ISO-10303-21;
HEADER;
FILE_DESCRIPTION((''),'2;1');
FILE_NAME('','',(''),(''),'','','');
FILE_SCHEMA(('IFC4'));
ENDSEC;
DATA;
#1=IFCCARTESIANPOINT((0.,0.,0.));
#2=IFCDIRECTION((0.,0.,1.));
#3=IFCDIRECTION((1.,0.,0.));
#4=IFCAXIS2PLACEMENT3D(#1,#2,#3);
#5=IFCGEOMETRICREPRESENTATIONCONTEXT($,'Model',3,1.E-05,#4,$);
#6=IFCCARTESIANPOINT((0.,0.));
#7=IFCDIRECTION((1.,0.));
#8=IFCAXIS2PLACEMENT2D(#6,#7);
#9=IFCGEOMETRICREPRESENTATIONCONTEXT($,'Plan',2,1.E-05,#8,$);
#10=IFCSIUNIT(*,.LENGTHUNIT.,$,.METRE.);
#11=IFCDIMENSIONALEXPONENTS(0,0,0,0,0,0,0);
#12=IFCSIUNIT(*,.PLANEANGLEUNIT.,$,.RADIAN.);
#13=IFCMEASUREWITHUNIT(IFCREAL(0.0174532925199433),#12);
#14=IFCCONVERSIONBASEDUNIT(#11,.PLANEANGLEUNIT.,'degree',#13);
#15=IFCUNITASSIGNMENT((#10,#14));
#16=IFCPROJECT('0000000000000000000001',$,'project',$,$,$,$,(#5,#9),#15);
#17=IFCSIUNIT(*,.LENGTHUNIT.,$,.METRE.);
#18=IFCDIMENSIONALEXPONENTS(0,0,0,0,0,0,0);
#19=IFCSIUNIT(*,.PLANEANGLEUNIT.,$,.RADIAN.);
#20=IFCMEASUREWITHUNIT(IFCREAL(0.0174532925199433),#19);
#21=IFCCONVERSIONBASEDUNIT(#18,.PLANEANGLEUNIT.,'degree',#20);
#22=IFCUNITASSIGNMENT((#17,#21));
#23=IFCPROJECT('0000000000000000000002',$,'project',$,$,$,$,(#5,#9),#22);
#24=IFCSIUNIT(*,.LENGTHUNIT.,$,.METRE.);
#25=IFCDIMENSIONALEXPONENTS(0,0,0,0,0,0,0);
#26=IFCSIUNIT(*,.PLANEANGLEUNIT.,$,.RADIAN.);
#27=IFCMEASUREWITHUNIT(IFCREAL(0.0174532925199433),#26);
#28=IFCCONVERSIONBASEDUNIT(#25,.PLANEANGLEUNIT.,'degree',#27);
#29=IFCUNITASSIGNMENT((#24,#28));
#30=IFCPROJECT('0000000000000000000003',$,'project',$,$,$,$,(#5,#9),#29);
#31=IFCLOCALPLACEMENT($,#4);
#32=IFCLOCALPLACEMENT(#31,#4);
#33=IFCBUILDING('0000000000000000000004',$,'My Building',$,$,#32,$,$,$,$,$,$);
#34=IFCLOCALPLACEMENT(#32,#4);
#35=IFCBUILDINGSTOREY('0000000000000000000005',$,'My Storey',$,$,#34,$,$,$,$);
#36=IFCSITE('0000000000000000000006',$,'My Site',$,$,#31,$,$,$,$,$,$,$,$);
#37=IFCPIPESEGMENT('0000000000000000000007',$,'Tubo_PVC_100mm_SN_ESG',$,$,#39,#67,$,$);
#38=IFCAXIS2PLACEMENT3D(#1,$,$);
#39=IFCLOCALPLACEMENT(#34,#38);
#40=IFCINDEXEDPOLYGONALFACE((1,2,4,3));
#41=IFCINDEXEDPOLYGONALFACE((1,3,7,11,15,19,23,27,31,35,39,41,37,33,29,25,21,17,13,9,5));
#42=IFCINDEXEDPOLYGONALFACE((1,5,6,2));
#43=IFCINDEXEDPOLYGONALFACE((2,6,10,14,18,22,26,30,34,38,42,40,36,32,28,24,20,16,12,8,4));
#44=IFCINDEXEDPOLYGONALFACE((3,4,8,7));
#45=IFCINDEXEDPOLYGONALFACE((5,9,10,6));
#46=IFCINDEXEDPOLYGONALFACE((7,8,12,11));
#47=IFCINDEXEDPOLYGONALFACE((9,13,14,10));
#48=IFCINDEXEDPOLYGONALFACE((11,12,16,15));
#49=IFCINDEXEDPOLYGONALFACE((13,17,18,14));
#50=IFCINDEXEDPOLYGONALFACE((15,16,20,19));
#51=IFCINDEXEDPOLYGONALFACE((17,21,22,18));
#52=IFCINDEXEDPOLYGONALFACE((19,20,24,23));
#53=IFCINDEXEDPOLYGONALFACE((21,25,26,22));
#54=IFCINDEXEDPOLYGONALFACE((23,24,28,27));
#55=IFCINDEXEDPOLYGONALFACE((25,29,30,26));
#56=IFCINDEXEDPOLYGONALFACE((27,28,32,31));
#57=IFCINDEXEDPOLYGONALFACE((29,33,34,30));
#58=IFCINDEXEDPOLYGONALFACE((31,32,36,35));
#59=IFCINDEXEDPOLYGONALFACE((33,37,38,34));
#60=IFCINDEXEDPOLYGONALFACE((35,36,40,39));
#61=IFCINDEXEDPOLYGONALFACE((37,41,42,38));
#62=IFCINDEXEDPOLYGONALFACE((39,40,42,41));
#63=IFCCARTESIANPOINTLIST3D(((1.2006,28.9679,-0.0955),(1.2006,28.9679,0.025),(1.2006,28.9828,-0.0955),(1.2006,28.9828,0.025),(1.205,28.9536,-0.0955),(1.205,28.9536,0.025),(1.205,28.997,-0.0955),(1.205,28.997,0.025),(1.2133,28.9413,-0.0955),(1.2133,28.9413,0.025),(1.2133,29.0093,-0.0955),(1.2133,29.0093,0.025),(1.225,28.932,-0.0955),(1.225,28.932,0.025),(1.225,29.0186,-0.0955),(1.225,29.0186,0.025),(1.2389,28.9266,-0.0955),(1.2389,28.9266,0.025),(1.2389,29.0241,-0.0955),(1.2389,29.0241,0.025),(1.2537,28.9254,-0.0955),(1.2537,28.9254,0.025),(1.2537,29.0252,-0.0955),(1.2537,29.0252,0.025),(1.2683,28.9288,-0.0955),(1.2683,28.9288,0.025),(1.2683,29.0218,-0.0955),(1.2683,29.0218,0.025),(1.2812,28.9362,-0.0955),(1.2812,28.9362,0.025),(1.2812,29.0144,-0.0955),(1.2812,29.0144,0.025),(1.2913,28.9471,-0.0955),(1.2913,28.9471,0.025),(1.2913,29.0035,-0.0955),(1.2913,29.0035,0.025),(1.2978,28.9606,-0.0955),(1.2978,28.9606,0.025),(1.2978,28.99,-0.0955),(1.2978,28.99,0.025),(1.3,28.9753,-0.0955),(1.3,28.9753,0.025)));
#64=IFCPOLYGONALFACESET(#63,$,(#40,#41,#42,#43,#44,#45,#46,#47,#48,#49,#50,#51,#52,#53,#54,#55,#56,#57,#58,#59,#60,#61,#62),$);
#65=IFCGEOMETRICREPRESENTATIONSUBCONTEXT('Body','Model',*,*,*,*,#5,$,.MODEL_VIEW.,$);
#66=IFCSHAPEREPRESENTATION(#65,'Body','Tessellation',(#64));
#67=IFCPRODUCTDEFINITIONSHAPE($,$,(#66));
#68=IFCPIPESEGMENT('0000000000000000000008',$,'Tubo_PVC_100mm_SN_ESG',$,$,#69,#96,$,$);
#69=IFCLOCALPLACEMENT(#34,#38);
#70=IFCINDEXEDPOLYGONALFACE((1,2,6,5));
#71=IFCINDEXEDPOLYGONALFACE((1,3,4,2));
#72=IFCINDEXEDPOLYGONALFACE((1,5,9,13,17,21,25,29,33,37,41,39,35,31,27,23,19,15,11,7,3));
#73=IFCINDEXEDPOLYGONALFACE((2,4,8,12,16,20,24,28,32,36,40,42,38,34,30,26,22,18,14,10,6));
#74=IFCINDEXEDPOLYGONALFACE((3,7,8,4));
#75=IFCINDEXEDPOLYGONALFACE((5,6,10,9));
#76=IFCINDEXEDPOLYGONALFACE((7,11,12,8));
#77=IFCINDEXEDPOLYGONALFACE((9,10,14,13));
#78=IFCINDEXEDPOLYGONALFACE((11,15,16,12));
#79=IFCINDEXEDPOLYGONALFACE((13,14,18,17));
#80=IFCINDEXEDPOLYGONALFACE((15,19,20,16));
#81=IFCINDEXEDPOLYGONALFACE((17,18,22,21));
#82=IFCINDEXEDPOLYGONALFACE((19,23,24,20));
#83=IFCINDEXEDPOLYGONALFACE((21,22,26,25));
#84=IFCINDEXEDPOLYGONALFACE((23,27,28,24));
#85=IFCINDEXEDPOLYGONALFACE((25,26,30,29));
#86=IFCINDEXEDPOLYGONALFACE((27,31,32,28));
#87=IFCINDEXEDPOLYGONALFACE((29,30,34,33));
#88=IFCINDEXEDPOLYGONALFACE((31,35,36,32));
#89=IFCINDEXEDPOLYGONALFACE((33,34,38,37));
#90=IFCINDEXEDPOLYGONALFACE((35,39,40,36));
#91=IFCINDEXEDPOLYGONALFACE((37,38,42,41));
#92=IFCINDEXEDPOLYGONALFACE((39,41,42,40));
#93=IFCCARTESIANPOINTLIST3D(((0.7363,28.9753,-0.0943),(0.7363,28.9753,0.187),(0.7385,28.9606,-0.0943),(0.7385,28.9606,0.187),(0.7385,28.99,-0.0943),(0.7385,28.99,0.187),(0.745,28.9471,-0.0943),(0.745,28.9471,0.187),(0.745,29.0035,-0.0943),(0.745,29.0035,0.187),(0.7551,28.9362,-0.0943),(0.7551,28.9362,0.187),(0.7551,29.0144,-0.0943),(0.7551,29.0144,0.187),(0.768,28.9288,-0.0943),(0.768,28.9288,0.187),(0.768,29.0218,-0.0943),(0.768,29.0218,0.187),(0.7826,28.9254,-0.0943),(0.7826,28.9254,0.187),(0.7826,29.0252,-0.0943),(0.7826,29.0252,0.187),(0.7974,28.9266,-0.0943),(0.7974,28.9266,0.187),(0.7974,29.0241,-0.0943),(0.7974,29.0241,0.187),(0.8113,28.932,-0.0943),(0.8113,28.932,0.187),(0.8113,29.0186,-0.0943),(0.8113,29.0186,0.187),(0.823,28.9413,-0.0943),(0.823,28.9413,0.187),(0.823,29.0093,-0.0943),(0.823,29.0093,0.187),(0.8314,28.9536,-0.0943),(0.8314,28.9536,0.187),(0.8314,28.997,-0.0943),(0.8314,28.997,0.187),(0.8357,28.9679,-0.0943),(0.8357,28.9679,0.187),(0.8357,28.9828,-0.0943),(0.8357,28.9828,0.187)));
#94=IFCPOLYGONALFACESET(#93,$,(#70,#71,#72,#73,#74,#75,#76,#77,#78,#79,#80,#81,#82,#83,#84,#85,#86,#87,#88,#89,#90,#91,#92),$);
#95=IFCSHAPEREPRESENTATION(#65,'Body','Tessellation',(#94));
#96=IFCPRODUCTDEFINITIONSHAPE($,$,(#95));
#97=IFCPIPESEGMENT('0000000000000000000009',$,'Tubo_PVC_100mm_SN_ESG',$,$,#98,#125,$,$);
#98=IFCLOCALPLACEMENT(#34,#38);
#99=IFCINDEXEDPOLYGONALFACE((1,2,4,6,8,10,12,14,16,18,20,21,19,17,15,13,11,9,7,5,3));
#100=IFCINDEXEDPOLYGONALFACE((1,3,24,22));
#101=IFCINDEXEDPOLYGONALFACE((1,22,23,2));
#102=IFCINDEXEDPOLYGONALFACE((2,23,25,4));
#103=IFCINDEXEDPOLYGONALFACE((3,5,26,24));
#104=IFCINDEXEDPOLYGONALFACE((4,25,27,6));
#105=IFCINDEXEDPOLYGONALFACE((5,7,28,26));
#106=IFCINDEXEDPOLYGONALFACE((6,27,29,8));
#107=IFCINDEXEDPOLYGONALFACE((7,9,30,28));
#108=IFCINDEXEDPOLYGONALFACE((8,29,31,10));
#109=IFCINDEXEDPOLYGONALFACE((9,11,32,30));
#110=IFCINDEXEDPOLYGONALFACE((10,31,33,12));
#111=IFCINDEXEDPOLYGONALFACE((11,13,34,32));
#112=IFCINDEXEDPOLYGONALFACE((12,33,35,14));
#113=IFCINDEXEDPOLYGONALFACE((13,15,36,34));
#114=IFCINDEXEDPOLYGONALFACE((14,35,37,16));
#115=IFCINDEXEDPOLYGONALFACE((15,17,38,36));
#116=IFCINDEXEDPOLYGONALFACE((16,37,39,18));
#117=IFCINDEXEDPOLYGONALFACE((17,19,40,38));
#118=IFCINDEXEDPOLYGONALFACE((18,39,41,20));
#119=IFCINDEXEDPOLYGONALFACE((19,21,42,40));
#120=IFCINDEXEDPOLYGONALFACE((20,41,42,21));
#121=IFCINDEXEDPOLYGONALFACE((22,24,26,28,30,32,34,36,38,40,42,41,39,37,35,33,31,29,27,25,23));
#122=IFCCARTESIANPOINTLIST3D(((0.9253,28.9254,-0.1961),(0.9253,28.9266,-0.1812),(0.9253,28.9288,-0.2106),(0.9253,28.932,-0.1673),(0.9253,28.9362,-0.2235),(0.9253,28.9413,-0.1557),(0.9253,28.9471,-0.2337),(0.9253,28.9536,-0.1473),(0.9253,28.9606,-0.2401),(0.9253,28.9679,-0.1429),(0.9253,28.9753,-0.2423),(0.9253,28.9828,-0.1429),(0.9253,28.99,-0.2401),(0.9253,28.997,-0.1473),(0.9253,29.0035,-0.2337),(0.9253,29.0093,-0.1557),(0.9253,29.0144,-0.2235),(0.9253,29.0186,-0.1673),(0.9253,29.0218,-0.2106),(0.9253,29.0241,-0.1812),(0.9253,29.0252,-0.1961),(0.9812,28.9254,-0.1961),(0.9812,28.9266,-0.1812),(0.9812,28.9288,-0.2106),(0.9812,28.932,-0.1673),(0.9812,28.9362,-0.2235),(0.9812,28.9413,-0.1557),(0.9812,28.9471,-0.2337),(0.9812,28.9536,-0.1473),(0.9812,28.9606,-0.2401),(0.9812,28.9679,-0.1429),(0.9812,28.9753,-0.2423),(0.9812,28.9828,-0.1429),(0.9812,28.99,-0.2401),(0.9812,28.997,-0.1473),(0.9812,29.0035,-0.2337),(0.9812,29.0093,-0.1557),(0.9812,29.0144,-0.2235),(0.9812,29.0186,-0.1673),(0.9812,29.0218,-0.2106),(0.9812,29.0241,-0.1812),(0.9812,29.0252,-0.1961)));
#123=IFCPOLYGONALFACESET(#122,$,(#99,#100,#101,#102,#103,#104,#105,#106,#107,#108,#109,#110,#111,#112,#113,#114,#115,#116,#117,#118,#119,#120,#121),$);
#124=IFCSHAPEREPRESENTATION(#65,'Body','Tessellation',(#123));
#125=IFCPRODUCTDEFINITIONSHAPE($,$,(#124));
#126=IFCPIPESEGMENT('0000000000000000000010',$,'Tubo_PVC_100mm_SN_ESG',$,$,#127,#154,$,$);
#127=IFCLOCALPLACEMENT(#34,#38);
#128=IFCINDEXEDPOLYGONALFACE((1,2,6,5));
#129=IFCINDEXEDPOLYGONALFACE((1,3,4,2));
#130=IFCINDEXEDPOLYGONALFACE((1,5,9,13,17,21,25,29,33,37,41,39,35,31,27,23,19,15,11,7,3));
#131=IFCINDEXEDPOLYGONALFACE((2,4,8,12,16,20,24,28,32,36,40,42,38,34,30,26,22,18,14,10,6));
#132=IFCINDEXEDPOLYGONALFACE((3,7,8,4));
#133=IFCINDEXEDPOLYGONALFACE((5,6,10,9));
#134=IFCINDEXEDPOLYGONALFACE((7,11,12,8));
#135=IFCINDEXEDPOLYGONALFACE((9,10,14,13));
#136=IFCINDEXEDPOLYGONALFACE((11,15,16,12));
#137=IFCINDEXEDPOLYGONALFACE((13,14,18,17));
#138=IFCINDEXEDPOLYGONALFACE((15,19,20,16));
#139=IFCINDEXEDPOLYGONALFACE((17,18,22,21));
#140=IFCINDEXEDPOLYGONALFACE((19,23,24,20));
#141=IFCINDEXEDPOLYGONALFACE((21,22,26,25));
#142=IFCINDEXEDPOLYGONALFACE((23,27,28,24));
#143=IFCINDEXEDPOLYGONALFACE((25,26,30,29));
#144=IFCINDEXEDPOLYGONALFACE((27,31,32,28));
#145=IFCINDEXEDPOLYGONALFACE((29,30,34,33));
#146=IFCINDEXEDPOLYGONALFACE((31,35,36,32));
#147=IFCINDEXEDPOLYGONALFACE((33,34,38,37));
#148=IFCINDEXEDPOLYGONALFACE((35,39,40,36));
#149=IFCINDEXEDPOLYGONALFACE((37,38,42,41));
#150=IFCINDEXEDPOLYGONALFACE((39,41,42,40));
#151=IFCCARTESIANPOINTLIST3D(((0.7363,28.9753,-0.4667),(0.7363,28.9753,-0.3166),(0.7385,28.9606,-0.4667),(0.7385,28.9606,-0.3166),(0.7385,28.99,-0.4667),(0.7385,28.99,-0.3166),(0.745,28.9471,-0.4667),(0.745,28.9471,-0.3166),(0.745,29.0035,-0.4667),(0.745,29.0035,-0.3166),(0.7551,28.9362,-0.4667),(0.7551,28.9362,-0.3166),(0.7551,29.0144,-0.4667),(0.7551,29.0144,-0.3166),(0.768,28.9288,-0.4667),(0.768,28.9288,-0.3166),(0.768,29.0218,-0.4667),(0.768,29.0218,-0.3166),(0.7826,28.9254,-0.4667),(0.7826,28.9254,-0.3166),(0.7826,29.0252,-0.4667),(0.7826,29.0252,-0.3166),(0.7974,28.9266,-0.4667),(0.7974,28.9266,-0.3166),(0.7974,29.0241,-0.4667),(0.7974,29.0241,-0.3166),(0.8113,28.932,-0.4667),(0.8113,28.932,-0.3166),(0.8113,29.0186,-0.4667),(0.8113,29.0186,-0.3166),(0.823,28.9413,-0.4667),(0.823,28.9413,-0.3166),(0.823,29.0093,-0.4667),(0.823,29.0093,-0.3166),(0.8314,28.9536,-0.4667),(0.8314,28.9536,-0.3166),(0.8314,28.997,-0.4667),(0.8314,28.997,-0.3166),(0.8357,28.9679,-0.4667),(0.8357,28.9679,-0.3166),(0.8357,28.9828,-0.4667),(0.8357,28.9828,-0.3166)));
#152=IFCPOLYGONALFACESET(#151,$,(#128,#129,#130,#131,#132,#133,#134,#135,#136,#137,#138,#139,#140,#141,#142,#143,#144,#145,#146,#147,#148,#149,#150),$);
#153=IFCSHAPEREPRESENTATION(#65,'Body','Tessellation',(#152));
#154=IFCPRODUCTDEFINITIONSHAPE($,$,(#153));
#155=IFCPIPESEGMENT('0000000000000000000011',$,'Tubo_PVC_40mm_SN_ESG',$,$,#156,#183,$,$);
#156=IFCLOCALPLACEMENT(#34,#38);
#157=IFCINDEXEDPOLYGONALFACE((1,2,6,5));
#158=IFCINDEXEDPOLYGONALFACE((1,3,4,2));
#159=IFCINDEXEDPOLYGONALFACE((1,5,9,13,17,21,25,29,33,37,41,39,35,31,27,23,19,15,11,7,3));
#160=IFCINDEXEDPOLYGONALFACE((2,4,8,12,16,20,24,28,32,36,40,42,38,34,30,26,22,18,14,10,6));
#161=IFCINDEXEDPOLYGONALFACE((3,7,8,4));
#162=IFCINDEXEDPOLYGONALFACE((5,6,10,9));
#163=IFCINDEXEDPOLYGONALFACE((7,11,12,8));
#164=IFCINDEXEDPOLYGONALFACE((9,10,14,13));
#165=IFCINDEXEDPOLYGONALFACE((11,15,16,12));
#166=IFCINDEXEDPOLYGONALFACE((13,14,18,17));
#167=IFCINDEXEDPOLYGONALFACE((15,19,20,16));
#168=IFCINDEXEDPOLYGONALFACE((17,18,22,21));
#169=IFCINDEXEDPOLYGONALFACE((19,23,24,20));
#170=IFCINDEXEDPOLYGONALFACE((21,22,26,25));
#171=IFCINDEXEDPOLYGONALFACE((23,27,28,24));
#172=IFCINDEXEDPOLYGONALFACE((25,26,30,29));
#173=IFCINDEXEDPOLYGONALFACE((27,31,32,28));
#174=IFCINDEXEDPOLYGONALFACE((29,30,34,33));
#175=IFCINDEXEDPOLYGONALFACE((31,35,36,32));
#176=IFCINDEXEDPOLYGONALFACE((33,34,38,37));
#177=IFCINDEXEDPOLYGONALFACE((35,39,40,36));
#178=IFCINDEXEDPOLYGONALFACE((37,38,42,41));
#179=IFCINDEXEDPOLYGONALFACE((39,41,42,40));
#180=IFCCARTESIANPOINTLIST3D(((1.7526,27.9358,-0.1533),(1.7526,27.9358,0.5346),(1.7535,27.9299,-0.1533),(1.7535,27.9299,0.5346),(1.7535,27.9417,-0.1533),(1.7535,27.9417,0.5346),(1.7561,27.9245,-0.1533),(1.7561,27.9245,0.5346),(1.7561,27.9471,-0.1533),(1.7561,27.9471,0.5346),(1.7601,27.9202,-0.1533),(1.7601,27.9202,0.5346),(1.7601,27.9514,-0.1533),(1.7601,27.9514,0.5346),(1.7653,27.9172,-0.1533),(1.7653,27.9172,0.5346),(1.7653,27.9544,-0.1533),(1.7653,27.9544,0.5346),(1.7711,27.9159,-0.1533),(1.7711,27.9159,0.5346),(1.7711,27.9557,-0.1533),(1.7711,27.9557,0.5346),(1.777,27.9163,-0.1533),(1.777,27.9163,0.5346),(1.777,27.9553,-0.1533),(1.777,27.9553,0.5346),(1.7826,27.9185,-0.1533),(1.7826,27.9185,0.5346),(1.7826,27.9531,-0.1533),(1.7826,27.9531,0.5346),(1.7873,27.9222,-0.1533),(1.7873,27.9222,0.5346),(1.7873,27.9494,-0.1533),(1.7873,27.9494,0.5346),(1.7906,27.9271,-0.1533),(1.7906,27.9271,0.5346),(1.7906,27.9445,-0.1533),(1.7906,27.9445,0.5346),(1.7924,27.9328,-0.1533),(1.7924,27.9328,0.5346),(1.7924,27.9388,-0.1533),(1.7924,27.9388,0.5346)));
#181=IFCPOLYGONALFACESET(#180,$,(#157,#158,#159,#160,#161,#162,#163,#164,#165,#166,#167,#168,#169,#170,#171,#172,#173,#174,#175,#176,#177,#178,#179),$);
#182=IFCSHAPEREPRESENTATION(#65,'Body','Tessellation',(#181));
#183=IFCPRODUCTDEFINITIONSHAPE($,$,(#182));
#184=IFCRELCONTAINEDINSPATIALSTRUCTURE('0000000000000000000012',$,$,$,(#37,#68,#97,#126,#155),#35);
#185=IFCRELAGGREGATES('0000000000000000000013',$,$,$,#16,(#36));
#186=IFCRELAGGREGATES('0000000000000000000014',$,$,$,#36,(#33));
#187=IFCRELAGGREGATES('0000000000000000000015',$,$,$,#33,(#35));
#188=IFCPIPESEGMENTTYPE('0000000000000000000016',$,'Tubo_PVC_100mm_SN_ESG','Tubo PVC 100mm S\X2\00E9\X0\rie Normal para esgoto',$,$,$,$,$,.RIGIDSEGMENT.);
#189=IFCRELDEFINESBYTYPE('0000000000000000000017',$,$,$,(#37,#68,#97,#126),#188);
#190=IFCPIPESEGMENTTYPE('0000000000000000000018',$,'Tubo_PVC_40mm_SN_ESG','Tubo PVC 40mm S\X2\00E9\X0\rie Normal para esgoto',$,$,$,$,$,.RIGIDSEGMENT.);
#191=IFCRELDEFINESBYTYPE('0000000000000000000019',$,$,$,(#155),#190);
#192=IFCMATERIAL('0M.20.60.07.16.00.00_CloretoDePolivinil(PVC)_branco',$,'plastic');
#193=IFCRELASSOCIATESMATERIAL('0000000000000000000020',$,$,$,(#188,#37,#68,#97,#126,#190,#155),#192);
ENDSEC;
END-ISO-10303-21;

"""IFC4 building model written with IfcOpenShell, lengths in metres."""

from ifc_helpers import new_model, entity, si_unit, converted_unit, frame, origin_with_axes, origin_2d_with_axis, place, context, subcontext, project, spatial, circle, extrude, material, material_profile, profile_set, profile_usage, type_object, element, save


model = new_model("IFC4")

# Units and contexts
model_context = context("Model", 3, precision=1e-05, world=origin_with_axes())
plan_context = context("Plan", 2, precision=1e-05, world=origin_2d_with_axis())
body_context_1 = subcontext(model_context, "Body", "Model", "MODEL_VIEW")
ifc_project_1 = project(units=[si_unit("LENGTHUNIT", "METRE"), converted_unit("PLANEANGLEUNIT", "degree", entity("IfcReal", 0.0174532925199433), si_unit("PLANEANGLEUNIT", "RADIAN"), dimensions=[0, 0, 0, 0, 0, 0, 0])], contexts=[model_context, plan_context])
ifc_project_2 = project(units=[si_unit("LENGTHUNIT", "METRE"), converted_unit("PLANEANGLEUNIT", "degree", entity("IfcReal", 0.0174532925199433), si_unit("PLANEANGLEUNIT", "RADIAN"), dimensions=[0, 0, 0, 0, 0, 0, 0])], contexts=[model_context, plan_context])
ifc_project_3 = project(units=[si_unit("LENGTHUNIT", "METRE"), converted_unit("PLANEANGLEUNIT", "degree", entity("IfcReal", 0.0174532925199433), si_unit("PLANEANGLEUNIT", "RADIAN"), dimensions=[0, 0, 0, 0, 0, 0, 0])], contexts=[model_context, plan_context])

# Site, building, storey
site_placement = place(None, origin_with_axes())
site = spatial("IfcSite", under=ifc_project_1, at=site_placement, Name="My Site")
building_placement = place(site_placement, origin_with_axes())
building = spatial("IfcBuilding", under=site, at=building_placement, Name="My Building")
storey_placement = place(building_placement, origin_with_axes())
storey = spatial("IfcBuildingStorey", under=building, at=storey_placement, Name="My Storey")

# Pipe segments
ifc_material_1 = material(Name="0M.20.60.07.16.00.00_CloretoDePolivinil(PVC)_branco", Category="plastic")
ifc_material_profile_1 = material_profile(ifc_material_1, circle(Radius=0.05))
ifc_profile_set_1 = profile_set([ifc_material_profile_1])
ifc_profile_usage_1 = profile_usage(ifc_profile_set_1, cardinal=5)
pipe_segment_type_1 = type_object("IfcPipeSegmentType", Name="Tubo_PVC_100mm_SN_ESG", Description="Tubo PVC 100mm Série Normal para esgoto", PredefinedType="RIGIDSEGMENT", material=ifc_profile_set_1)
pipe_segment_1_placement = place(storey_placement, frame((1.25, 28.9753, -0.0955), z_axis=(0.0, 0.0, 1.0), x_axis=(1.0, 0.0, 0.0)))
element("IfcPipeSegment", 1, at=pipe_segment_1_placement, inside=storey, type_object=pipe_segment_type_1, material=ifc_profile_usage_1, Name="Tubo_PVC_100mm_SN_ESG", context=body_context_1, shape_type="SweptSolid", body=[
    extrude(circle(Radius=0.05), origin_with_axes(), (0.0, 0.0, 1.0), 0.1205),
])
ifc_profile_usage_2 = profile_usage(ifc_profile_set_1, cardinal=5)
pipe_segment_2_placement = place(storey_placement, frame((0.7863, 28.9753, 0.187), z_axis=(0.0, 0.0, -1.0), x_axis=(-1.0, 0.0, 0.0)))
element("IfcPipeSegment", 2, at=pipe_segment_2_placement, inside=storey, type_object=pipe_segment_type_1, material=ifc_profile_usage_2, Name="Tubo_PVC_100mm_SN_ESG", context=body_context_1, shape_type="SweptSolid", body=[
    extrude(circle(Radius=0.05), origin_with_axes(), (0.0, 0.0, 1.0), 0.2814),
])
ifc_profile_usage_3 = profile_usage(ifc_profile_set_1, cardinal=5)
pipe_segment_3_placement = place(storey_placement, frame((0.9253, 28.9753, -0.1923), z_axis=(1.0, 0.0, 0.000001), x_axis=(0.000001, 0.0, -1.0)))
element("IfcPipeSegment", 3, at=pipe_segment_3_placement, inside=storey, type_object=pipe_segment_type_1, material=ifc_profile_usage_3, Name="Tubo_PVC_100mm_SN_ESG", context=body_context_1, shape_type="SweptSolid", body=[
    extrude(circle(Radius=0.05), origin_with_axes(), (0.0, 0.0, 1.0), 0.0559),
])
ifc_profile_usage_4 = profile_usage(ifc_profile_set_1, cardinal=5)
pipe_segment_4_placement = place(storey_placement, frame((0.7863, 28.9753, -0.3166), z_axis=(0.0, 0.0, -1.0), x_axis=(-1.0, 0.0, 0.0)))
element("IfcPipeSegment", 4, at=pipe_segment_4_placement, inside=storey, type_object=pipe_segment_type_1, material=ifc_profile_usage_4, Name="Tubo_PVC_100mm_SN_ESG", context=body_context_1, shape_type="SweptSolid", body=[
    extrude(circle(Radius=0.05), origin_with_axes(), (0.0, 0.0, 1.0), 0.15),
])
ifc_material_profile_2 = material_profile(ifc_material_1, circle(Radius=0.02))
ifc_profile_set_2 = profile_set([ifc_material_profile_2])
ifc_profile_usage_5 = profile_usage(ifc_profile_set_2, cardinal=5)
pipe_segment_type_2 = type_object("IfcPipeSegmentType", Name="Tubo_PVC_40mm_SN_ESG", Description="Tubo PVC 40mm Série Normal para esgoto", PredefinedType="RIGIDSEGMENT", material=ifc_profile_set_2)
pipe_segment_5_placement = place(storey_placement, frame((1.7726, 27.9358, 0.5346), z_axis=(0.0, 0.0, -1.0), x_axis=(-1.0, 0.0, 0.0)))
element("IfcPipeSegment", 5, at=pipe_segment_5_placement, inside=storey, type_object=pipe_segment_type_2, material=ifc_profile_usage_5, Name="Tubo_PVC_40mm_SN_ESG", context=body_context_1, shape_type="SweptSolid", body=[
    extrude(circle(Radius=0.02), origin_with_axes(), (0.0, 0.0, 1.0), 0.6879),
])

save(model, "model.ifc")
